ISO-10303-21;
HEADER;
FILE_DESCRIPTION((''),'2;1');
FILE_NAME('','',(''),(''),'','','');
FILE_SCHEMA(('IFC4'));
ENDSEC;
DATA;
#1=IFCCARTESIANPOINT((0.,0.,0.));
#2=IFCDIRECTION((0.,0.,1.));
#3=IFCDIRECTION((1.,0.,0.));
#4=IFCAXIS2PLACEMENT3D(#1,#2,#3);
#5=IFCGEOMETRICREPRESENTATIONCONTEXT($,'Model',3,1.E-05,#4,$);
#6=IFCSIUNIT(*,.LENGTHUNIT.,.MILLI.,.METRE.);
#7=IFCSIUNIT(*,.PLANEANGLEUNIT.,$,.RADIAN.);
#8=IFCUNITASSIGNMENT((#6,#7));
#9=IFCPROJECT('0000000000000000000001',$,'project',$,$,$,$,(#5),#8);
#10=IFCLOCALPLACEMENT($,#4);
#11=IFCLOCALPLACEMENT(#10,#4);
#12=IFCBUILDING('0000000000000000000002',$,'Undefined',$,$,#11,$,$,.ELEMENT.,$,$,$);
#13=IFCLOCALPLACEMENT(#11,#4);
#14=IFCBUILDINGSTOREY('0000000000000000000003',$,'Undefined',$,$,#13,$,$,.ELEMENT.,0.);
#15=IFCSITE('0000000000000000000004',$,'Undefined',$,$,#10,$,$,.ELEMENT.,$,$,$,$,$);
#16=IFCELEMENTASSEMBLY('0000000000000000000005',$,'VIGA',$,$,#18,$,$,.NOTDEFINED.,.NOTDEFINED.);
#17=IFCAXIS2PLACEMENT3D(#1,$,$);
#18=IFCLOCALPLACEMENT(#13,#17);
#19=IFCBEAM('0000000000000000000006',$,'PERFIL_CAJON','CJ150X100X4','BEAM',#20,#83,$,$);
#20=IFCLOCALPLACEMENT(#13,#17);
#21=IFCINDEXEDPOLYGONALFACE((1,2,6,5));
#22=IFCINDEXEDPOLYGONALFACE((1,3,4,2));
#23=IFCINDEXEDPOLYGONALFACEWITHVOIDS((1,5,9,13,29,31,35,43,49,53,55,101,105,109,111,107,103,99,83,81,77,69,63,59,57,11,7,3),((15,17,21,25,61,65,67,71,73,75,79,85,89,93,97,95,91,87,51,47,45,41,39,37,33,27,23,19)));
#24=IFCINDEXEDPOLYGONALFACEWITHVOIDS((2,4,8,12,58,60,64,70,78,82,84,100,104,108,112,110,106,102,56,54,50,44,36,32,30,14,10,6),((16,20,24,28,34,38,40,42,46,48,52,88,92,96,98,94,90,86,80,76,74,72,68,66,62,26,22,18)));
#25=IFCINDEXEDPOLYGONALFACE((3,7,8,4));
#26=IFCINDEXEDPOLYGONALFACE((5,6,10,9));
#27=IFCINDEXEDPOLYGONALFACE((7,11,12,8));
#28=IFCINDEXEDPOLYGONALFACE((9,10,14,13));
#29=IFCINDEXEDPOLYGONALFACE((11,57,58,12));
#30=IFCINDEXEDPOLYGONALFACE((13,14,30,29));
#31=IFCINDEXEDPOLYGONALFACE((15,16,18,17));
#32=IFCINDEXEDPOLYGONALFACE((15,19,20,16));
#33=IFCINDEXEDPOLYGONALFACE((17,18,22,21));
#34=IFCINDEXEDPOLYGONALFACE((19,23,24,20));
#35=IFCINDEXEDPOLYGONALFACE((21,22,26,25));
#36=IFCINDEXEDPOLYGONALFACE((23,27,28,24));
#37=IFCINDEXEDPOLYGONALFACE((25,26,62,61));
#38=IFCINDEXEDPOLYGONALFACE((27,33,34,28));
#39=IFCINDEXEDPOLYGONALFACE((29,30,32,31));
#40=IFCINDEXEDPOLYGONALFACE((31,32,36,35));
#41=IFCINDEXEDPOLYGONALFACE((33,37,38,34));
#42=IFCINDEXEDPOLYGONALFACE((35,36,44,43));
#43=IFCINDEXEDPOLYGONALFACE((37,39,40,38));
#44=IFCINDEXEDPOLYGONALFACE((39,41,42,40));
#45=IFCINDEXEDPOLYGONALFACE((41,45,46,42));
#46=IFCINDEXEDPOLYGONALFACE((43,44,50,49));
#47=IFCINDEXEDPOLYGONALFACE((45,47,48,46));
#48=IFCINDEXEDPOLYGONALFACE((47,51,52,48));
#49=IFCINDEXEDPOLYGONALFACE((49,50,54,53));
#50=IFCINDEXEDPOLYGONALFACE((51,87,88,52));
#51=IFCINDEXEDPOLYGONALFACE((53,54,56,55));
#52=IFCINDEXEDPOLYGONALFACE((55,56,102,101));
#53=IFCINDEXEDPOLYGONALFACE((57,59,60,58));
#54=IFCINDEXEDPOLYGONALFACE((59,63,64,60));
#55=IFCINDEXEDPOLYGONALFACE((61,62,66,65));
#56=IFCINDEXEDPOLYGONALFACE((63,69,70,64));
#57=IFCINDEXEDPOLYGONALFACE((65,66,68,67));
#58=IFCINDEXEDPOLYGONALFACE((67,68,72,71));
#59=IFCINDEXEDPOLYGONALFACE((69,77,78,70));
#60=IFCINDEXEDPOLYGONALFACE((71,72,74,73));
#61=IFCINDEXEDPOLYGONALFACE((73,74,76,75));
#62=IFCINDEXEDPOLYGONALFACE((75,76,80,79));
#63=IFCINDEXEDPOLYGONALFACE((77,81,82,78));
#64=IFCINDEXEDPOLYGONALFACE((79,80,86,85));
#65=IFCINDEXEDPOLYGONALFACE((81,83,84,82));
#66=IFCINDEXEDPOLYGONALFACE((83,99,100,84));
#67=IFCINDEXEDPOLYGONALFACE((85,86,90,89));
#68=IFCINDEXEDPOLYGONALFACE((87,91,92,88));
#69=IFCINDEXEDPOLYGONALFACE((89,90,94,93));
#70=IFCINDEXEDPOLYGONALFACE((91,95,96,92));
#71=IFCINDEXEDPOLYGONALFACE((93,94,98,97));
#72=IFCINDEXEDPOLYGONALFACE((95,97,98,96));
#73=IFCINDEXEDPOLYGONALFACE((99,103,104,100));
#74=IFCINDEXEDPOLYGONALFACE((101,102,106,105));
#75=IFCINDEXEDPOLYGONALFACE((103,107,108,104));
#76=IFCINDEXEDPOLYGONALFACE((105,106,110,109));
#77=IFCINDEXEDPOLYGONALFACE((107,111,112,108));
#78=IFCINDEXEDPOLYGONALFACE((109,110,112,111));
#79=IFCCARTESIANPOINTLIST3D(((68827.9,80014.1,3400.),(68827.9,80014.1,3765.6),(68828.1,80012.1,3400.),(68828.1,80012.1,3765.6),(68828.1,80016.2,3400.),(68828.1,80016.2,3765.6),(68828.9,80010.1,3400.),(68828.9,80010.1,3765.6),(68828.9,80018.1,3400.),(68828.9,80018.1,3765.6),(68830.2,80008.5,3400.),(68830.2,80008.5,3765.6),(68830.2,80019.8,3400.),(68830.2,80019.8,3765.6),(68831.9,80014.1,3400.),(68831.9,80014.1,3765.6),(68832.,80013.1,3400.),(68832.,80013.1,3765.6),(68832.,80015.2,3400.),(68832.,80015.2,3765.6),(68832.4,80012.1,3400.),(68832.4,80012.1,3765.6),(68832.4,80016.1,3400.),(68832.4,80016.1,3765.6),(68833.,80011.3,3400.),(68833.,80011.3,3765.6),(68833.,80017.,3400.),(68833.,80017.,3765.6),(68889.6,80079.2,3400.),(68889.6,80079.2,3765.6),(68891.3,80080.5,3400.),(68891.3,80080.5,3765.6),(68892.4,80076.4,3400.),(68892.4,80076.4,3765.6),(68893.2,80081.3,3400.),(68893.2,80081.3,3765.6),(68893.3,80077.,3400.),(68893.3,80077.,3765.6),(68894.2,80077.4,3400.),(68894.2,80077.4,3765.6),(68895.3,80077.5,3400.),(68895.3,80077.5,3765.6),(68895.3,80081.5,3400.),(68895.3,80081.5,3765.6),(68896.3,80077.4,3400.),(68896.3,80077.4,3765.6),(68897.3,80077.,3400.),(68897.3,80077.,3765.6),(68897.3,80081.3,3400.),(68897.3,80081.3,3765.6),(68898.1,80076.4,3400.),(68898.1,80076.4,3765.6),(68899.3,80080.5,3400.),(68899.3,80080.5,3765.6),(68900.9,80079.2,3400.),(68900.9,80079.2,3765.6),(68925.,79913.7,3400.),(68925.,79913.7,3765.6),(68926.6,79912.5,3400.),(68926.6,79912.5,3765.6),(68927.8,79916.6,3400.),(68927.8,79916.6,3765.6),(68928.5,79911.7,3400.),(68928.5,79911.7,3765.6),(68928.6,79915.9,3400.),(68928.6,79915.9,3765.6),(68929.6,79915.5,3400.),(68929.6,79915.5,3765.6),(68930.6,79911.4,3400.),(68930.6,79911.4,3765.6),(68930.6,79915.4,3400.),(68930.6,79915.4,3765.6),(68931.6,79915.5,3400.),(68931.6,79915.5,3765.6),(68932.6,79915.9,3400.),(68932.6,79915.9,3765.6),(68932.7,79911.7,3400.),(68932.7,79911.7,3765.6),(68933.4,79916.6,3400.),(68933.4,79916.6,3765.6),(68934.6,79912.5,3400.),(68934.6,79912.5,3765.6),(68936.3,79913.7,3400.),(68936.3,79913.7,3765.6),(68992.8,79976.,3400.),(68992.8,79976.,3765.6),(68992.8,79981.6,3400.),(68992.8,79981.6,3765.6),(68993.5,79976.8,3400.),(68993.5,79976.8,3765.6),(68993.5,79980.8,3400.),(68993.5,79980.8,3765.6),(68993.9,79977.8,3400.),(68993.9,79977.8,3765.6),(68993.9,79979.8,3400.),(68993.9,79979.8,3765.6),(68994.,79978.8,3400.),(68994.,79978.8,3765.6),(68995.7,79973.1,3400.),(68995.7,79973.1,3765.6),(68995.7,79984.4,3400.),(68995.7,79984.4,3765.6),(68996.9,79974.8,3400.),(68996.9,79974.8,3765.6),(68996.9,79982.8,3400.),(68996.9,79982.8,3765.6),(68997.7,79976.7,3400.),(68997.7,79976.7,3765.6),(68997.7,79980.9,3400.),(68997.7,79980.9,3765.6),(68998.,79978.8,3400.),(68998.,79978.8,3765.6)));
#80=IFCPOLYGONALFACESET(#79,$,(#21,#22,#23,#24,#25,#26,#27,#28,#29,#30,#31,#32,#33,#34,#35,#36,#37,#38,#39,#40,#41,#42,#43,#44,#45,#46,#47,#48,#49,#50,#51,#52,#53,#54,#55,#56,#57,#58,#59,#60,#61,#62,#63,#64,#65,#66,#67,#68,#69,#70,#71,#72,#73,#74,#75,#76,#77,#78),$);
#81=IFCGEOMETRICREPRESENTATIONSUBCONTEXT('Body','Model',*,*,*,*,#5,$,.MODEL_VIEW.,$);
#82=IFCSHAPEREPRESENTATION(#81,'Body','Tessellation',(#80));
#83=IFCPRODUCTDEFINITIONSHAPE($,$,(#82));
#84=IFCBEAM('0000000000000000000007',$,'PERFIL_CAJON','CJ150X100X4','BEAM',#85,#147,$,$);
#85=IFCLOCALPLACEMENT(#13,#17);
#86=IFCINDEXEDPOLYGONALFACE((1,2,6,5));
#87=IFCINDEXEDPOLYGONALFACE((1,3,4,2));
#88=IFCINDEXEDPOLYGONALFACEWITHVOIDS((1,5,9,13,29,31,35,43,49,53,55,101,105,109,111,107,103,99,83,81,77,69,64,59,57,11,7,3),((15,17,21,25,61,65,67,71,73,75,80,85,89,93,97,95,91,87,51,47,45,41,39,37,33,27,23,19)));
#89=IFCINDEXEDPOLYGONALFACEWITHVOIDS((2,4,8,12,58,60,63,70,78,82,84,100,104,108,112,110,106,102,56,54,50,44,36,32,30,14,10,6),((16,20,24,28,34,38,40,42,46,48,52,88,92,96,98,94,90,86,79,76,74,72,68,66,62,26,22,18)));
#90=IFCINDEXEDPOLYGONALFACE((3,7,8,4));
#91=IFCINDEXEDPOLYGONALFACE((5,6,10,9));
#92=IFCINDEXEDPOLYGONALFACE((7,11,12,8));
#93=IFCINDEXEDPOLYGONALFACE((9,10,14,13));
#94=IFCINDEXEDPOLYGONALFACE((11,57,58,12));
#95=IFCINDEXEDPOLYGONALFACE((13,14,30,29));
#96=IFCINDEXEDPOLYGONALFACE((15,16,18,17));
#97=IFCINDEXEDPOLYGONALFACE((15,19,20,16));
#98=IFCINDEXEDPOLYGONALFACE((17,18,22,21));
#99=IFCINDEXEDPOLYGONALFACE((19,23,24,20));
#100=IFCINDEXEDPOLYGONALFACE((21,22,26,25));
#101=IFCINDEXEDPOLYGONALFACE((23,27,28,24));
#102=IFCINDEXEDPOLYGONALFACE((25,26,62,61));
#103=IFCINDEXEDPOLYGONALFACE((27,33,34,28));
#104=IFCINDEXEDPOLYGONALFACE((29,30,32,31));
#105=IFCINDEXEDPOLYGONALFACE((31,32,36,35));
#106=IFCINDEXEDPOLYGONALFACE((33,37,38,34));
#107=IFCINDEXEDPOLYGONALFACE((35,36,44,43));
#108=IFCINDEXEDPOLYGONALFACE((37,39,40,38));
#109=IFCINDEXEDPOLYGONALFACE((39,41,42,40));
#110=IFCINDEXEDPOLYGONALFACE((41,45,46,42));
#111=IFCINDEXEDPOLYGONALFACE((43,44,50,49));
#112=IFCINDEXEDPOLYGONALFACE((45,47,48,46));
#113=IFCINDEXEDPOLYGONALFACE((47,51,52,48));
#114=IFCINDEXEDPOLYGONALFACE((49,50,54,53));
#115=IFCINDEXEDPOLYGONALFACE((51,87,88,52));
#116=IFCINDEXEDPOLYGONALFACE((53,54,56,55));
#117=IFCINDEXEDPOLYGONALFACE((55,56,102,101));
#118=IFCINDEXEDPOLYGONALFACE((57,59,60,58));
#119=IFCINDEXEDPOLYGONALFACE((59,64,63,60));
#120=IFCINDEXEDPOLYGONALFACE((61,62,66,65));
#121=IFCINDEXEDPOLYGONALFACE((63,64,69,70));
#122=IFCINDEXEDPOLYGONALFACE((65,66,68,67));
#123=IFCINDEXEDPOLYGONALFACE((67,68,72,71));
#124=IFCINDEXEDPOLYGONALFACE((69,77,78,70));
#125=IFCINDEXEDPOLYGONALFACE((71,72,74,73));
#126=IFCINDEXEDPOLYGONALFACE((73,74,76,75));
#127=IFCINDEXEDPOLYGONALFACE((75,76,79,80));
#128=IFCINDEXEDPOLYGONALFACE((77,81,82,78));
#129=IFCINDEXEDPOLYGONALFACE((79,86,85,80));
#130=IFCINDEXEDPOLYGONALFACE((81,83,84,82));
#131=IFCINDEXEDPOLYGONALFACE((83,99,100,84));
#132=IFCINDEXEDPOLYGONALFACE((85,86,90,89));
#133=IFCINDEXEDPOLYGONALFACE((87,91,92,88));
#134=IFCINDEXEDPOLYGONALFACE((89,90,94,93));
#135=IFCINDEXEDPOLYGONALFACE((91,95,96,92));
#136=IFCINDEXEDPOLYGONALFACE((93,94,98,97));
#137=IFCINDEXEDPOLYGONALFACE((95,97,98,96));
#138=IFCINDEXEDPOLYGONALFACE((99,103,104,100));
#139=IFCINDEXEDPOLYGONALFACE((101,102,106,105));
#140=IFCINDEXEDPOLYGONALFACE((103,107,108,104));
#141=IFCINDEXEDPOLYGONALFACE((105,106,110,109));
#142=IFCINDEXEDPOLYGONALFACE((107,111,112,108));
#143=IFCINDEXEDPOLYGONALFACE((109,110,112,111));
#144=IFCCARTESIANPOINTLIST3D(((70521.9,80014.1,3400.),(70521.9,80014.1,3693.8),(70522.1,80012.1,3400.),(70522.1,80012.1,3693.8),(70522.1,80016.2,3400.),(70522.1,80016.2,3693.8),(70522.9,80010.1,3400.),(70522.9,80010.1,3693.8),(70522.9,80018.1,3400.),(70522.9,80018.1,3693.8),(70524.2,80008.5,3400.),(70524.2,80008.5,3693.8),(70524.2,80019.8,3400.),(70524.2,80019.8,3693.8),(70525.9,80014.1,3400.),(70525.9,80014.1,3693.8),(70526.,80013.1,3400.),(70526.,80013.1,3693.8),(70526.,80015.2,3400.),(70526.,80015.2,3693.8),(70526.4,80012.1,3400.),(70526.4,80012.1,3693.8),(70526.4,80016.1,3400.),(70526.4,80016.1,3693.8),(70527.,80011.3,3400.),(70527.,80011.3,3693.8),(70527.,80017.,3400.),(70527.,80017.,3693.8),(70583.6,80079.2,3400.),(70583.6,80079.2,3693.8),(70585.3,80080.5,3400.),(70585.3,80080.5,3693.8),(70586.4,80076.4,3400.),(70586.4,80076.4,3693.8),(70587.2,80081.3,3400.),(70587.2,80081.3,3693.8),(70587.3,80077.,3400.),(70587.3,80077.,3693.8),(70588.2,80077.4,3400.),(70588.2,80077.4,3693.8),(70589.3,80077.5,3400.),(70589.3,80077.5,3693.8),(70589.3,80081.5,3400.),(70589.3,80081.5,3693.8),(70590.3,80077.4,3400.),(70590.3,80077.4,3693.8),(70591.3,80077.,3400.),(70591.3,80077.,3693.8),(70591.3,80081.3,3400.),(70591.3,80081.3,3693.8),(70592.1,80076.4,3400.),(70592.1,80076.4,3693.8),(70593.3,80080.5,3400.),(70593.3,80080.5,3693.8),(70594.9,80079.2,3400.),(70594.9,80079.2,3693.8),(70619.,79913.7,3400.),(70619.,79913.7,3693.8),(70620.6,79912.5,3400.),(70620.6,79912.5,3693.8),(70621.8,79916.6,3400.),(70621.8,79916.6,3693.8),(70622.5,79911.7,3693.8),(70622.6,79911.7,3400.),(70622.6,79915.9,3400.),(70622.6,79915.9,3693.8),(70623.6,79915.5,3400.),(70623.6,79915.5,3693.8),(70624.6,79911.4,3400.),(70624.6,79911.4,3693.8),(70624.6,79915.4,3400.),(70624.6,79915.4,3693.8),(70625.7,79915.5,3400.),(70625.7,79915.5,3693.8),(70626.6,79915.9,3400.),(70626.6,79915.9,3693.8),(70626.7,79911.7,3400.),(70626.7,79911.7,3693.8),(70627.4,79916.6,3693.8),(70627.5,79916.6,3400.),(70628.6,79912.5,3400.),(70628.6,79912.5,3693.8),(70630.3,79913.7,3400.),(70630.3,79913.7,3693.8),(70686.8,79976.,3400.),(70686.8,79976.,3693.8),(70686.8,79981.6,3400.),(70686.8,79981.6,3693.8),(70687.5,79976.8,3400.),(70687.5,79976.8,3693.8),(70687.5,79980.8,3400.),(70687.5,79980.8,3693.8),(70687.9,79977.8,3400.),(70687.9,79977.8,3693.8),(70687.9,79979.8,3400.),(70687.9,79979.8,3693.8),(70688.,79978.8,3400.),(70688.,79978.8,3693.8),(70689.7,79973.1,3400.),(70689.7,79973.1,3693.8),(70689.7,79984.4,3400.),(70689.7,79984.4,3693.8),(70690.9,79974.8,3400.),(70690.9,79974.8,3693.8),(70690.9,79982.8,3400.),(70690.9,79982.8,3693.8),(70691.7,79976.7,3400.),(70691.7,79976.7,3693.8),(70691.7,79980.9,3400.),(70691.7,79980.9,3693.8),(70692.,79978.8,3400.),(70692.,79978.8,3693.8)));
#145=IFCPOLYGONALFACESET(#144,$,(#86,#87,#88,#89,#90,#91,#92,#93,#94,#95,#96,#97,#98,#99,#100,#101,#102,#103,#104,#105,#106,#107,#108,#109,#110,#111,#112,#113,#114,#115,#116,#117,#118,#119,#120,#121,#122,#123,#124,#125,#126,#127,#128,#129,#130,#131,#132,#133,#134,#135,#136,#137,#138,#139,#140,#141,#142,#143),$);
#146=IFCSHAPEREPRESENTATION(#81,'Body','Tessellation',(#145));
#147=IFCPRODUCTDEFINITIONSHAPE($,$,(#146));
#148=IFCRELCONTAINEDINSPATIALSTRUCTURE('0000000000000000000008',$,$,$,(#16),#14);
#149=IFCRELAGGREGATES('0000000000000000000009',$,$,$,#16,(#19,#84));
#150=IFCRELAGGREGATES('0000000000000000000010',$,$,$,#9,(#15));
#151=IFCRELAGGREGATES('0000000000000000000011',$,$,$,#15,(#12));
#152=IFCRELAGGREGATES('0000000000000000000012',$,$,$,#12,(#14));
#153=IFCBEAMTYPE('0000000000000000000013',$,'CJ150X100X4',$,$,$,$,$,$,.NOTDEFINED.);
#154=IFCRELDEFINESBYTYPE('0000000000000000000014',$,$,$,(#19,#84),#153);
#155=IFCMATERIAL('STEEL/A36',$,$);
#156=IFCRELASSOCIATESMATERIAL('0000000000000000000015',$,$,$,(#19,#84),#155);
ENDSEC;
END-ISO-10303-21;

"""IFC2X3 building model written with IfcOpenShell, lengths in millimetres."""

from ifc_helpers import new_model, si_unit, frame, origin_with_axes, origin_2d_with_axis, place, context, subcontext, project, spatial, hollow_rectangle, extrude, material, type_object, element, aggregate, save


model = new_model("IFC2X3")

# Units and contexts
model_context = context("Model", 3, precision=1e-05, world=origin_with_axes())
body_context = subcontext(model_context, "Body", "Model", "MODEL_VIEW")
ifc_project = project(units=[si_unit("LENGTHUNIT", "METRE", prefix="MILLI"), si_unit("PLANEANGLEUNIT", "RADIAN")], contexts=[model_context])

# Site, building, storey
site_placement = place(None, origin_with_axes())
site = spatial("IfcSite", under=ifc_project, at=site_placement, Name="Undefined", CompositionType="ELEMENT")
building_placement = place(site_placement, origin_with_axes())
building = spatial("IfcBuilding", under=site, at=building_placement, Name="Undefined", CompositionType="ELEMENT")
storey_placement = place(building_placement, origin_with_axes())
storey = spatial("IfcBuildingStorey", under=building, at=storey_placement, Name="Undefined", CompositionType="ELEMENT", Elevation=0.0)

# Element assembly, beams
assembly_1_placement = place(storey_placement, origin_with_axes())
assembly_1 = element("IfcElementAssembly", 1, at=assembly_1_placement, inside=storey, Name="VIGA", AssemblyPlace="NOTDEFINED", PredefinedType="NOTDEFINED")
ifc_material_1 = material(Name="STEEL/A36")
beam_type_1 = type_object("IfcBeamType", Name="CJ150X100X4", PredefinedType="NOTDEFINED")
beam_1_placement = place(assembly_1_placement, frame((68912.9, 79996.5, 3765.6), z_axis=(-0.707107, 0.707107, 0.0), x_axis=(0.000008, 0.000008, -1.0)))
beam_1 = element("IfcBeam", 2, at=beam_1_placement, type_object=beam_type_1, material=ifc_material_1, Name="PERFIL_CAJON", Description="CJ150X100X4", ObjectType="BEAM", context=body_context, shape_type="SweptSolid", body=[
    extrude(hollow_rectangle(XDim=100.0, YDim=150.0, WallThickness=4.0, InnerFilletRadius=4.0, OuterFilletRadius=8.0, at=origin_2d_with_axis()), frame((365.6, 0.0, 0.0), z_axis=(-1.0, 0.0, 0.0), x_axis=(0.0, -1.0, 0.0)), (0.0, 0.0, 1.0), 365.6),
])
beam_2_placement = place(assembly_1_placement, frame((70606.9, 79996.5, 3693.8), z_axis=(-0.707107, 0.707107, 0.0), x_axis=(0.000011, 0.000011, -1.0)))
beam_2 = element("IfcBeam", 3, at=beam_2_placement, type_object=beam_type_1, material=ifc_material_1, Name="PERFIL_CAJON", Description="CJ150X100X4", ObjectType="BEAM", context=body_context, shape_type="SweptSolid", body=[
    extrude(hollow_rectangle(XDim=100.0, YDim=150.0, WallThickness=4.0, InnerFilletRadius=4.0, OuterFilletRadius=8.0, at=origin_2d_with_axis()), frame((293.8, 0.0, 0.0), z_axis=(-1.0, 0.0, 0.0), x_axis=(0.0, -1.0, 0.0)), (0.0, 0.0, 1.0), 293.8),
])

aggregate(assembly_1, [beam_1, beam_2])

save(model, "model.ifc")
